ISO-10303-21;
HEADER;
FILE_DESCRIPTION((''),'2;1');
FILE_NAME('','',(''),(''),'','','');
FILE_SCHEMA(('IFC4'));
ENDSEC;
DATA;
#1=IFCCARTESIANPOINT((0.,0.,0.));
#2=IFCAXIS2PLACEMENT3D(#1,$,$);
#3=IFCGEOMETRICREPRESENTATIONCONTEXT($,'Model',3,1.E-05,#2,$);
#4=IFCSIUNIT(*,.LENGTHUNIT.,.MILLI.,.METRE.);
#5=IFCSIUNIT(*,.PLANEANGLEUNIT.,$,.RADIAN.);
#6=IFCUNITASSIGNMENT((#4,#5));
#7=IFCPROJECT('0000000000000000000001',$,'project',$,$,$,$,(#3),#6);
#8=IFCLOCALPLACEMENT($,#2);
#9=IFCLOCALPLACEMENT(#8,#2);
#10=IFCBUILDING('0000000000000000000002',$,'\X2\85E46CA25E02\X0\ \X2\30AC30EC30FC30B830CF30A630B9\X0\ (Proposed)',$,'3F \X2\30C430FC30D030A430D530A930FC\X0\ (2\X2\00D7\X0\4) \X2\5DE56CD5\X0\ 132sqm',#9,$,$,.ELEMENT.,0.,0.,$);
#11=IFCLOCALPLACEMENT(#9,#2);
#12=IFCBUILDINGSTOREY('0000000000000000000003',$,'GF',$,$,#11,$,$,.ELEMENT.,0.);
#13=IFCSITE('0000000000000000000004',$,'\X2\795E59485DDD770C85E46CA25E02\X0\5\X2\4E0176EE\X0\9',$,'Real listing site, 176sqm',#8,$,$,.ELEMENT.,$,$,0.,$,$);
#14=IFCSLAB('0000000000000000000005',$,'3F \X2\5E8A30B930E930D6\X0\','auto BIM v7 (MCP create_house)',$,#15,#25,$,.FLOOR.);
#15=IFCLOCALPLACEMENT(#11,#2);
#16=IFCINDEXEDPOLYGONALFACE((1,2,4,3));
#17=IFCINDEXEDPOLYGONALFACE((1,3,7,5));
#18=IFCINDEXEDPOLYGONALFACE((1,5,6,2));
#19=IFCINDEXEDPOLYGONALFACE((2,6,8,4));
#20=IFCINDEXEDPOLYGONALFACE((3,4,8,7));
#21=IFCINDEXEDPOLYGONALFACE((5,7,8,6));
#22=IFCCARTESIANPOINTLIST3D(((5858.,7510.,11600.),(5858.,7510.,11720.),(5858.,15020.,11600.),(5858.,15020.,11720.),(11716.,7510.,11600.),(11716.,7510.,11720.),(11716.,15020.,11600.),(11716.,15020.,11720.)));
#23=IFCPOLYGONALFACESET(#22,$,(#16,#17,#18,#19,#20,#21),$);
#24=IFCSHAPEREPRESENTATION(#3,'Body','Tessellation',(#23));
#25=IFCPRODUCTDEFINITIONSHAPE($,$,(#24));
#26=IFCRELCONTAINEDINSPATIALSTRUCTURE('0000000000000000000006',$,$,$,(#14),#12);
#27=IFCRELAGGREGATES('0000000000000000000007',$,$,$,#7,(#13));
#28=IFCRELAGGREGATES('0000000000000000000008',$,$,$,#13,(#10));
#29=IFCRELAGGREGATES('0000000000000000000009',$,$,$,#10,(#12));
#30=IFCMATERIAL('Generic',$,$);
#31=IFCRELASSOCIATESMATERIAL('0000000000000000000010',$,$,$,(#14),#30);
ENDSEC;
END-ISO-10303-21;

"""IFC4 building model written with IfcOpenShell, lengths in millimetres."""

from ifc_helpers import new_model, si_unit, frame, frame_2d, origin, place, context, project, spatial, rectangle, extrude, material, element, save


model = new_model("IFC4")

# Units and contexts
model_context = context("Model", 3, precision=1e-05, world=origin())
ifc_project = project(units=[si_unit("LENGTHUNIT", "METRE", prefix="MILLI"), si_unit("PLANEANGLEUNIT", "RADIAN")], contexts=[model_context])

# Site, building, storey
site_placement = place(None, origin())
site = spatial("IfcSite", under=ifc_project, at=site_placement, Name="神奈川県藤沢市5丁目9", ObjectType="Real listing site, 176sqm", CompositionType="ELEMENT", RefElevation=0.0)
building_placement = place(site_placement, origin())
building = spatial("IfcBuilding", under=site, at=building_placement, Name="藤沢市 ガレージハウス (Proposed)", ObjectType="3F ツーバイフォー (2×4) 工法 132sqm", CompositionType="ELEMENT", ElevationOfRefHeight=0.0, ElevationOfTerrain=0.0)
storey_placement = place(building_placement, origin())
storey = spatial("IfcBuildingStorey", under=building, at=storey_placement, Name="GF", CompositionType="ELEMENT", Elevation=0.0)

# Slab
ifc_material = material(Name="Generic")
slab_placement = place(storey_placement, frame((2929.0, 3755.0, 5800.0)))
element("IfcSlab", 1, at=slab_placement, inside=storey, material=ifc_material, Name="3F 床スラブ", Description="auto BIM v7 (MCP create_house)", PredefinedType="FLOOR", context=model_context, shape_type="SweptSolid", body=[
    extrude(rectangle(XDim=5858.0, YDim=7510.0, at=frame_2d((2929.0, 3755.0))), frame((2929.0, 3755.0, 5800.0)), (0.0, 0.0, 1.0), 120.0),
])

save(model, "model.ifc")
